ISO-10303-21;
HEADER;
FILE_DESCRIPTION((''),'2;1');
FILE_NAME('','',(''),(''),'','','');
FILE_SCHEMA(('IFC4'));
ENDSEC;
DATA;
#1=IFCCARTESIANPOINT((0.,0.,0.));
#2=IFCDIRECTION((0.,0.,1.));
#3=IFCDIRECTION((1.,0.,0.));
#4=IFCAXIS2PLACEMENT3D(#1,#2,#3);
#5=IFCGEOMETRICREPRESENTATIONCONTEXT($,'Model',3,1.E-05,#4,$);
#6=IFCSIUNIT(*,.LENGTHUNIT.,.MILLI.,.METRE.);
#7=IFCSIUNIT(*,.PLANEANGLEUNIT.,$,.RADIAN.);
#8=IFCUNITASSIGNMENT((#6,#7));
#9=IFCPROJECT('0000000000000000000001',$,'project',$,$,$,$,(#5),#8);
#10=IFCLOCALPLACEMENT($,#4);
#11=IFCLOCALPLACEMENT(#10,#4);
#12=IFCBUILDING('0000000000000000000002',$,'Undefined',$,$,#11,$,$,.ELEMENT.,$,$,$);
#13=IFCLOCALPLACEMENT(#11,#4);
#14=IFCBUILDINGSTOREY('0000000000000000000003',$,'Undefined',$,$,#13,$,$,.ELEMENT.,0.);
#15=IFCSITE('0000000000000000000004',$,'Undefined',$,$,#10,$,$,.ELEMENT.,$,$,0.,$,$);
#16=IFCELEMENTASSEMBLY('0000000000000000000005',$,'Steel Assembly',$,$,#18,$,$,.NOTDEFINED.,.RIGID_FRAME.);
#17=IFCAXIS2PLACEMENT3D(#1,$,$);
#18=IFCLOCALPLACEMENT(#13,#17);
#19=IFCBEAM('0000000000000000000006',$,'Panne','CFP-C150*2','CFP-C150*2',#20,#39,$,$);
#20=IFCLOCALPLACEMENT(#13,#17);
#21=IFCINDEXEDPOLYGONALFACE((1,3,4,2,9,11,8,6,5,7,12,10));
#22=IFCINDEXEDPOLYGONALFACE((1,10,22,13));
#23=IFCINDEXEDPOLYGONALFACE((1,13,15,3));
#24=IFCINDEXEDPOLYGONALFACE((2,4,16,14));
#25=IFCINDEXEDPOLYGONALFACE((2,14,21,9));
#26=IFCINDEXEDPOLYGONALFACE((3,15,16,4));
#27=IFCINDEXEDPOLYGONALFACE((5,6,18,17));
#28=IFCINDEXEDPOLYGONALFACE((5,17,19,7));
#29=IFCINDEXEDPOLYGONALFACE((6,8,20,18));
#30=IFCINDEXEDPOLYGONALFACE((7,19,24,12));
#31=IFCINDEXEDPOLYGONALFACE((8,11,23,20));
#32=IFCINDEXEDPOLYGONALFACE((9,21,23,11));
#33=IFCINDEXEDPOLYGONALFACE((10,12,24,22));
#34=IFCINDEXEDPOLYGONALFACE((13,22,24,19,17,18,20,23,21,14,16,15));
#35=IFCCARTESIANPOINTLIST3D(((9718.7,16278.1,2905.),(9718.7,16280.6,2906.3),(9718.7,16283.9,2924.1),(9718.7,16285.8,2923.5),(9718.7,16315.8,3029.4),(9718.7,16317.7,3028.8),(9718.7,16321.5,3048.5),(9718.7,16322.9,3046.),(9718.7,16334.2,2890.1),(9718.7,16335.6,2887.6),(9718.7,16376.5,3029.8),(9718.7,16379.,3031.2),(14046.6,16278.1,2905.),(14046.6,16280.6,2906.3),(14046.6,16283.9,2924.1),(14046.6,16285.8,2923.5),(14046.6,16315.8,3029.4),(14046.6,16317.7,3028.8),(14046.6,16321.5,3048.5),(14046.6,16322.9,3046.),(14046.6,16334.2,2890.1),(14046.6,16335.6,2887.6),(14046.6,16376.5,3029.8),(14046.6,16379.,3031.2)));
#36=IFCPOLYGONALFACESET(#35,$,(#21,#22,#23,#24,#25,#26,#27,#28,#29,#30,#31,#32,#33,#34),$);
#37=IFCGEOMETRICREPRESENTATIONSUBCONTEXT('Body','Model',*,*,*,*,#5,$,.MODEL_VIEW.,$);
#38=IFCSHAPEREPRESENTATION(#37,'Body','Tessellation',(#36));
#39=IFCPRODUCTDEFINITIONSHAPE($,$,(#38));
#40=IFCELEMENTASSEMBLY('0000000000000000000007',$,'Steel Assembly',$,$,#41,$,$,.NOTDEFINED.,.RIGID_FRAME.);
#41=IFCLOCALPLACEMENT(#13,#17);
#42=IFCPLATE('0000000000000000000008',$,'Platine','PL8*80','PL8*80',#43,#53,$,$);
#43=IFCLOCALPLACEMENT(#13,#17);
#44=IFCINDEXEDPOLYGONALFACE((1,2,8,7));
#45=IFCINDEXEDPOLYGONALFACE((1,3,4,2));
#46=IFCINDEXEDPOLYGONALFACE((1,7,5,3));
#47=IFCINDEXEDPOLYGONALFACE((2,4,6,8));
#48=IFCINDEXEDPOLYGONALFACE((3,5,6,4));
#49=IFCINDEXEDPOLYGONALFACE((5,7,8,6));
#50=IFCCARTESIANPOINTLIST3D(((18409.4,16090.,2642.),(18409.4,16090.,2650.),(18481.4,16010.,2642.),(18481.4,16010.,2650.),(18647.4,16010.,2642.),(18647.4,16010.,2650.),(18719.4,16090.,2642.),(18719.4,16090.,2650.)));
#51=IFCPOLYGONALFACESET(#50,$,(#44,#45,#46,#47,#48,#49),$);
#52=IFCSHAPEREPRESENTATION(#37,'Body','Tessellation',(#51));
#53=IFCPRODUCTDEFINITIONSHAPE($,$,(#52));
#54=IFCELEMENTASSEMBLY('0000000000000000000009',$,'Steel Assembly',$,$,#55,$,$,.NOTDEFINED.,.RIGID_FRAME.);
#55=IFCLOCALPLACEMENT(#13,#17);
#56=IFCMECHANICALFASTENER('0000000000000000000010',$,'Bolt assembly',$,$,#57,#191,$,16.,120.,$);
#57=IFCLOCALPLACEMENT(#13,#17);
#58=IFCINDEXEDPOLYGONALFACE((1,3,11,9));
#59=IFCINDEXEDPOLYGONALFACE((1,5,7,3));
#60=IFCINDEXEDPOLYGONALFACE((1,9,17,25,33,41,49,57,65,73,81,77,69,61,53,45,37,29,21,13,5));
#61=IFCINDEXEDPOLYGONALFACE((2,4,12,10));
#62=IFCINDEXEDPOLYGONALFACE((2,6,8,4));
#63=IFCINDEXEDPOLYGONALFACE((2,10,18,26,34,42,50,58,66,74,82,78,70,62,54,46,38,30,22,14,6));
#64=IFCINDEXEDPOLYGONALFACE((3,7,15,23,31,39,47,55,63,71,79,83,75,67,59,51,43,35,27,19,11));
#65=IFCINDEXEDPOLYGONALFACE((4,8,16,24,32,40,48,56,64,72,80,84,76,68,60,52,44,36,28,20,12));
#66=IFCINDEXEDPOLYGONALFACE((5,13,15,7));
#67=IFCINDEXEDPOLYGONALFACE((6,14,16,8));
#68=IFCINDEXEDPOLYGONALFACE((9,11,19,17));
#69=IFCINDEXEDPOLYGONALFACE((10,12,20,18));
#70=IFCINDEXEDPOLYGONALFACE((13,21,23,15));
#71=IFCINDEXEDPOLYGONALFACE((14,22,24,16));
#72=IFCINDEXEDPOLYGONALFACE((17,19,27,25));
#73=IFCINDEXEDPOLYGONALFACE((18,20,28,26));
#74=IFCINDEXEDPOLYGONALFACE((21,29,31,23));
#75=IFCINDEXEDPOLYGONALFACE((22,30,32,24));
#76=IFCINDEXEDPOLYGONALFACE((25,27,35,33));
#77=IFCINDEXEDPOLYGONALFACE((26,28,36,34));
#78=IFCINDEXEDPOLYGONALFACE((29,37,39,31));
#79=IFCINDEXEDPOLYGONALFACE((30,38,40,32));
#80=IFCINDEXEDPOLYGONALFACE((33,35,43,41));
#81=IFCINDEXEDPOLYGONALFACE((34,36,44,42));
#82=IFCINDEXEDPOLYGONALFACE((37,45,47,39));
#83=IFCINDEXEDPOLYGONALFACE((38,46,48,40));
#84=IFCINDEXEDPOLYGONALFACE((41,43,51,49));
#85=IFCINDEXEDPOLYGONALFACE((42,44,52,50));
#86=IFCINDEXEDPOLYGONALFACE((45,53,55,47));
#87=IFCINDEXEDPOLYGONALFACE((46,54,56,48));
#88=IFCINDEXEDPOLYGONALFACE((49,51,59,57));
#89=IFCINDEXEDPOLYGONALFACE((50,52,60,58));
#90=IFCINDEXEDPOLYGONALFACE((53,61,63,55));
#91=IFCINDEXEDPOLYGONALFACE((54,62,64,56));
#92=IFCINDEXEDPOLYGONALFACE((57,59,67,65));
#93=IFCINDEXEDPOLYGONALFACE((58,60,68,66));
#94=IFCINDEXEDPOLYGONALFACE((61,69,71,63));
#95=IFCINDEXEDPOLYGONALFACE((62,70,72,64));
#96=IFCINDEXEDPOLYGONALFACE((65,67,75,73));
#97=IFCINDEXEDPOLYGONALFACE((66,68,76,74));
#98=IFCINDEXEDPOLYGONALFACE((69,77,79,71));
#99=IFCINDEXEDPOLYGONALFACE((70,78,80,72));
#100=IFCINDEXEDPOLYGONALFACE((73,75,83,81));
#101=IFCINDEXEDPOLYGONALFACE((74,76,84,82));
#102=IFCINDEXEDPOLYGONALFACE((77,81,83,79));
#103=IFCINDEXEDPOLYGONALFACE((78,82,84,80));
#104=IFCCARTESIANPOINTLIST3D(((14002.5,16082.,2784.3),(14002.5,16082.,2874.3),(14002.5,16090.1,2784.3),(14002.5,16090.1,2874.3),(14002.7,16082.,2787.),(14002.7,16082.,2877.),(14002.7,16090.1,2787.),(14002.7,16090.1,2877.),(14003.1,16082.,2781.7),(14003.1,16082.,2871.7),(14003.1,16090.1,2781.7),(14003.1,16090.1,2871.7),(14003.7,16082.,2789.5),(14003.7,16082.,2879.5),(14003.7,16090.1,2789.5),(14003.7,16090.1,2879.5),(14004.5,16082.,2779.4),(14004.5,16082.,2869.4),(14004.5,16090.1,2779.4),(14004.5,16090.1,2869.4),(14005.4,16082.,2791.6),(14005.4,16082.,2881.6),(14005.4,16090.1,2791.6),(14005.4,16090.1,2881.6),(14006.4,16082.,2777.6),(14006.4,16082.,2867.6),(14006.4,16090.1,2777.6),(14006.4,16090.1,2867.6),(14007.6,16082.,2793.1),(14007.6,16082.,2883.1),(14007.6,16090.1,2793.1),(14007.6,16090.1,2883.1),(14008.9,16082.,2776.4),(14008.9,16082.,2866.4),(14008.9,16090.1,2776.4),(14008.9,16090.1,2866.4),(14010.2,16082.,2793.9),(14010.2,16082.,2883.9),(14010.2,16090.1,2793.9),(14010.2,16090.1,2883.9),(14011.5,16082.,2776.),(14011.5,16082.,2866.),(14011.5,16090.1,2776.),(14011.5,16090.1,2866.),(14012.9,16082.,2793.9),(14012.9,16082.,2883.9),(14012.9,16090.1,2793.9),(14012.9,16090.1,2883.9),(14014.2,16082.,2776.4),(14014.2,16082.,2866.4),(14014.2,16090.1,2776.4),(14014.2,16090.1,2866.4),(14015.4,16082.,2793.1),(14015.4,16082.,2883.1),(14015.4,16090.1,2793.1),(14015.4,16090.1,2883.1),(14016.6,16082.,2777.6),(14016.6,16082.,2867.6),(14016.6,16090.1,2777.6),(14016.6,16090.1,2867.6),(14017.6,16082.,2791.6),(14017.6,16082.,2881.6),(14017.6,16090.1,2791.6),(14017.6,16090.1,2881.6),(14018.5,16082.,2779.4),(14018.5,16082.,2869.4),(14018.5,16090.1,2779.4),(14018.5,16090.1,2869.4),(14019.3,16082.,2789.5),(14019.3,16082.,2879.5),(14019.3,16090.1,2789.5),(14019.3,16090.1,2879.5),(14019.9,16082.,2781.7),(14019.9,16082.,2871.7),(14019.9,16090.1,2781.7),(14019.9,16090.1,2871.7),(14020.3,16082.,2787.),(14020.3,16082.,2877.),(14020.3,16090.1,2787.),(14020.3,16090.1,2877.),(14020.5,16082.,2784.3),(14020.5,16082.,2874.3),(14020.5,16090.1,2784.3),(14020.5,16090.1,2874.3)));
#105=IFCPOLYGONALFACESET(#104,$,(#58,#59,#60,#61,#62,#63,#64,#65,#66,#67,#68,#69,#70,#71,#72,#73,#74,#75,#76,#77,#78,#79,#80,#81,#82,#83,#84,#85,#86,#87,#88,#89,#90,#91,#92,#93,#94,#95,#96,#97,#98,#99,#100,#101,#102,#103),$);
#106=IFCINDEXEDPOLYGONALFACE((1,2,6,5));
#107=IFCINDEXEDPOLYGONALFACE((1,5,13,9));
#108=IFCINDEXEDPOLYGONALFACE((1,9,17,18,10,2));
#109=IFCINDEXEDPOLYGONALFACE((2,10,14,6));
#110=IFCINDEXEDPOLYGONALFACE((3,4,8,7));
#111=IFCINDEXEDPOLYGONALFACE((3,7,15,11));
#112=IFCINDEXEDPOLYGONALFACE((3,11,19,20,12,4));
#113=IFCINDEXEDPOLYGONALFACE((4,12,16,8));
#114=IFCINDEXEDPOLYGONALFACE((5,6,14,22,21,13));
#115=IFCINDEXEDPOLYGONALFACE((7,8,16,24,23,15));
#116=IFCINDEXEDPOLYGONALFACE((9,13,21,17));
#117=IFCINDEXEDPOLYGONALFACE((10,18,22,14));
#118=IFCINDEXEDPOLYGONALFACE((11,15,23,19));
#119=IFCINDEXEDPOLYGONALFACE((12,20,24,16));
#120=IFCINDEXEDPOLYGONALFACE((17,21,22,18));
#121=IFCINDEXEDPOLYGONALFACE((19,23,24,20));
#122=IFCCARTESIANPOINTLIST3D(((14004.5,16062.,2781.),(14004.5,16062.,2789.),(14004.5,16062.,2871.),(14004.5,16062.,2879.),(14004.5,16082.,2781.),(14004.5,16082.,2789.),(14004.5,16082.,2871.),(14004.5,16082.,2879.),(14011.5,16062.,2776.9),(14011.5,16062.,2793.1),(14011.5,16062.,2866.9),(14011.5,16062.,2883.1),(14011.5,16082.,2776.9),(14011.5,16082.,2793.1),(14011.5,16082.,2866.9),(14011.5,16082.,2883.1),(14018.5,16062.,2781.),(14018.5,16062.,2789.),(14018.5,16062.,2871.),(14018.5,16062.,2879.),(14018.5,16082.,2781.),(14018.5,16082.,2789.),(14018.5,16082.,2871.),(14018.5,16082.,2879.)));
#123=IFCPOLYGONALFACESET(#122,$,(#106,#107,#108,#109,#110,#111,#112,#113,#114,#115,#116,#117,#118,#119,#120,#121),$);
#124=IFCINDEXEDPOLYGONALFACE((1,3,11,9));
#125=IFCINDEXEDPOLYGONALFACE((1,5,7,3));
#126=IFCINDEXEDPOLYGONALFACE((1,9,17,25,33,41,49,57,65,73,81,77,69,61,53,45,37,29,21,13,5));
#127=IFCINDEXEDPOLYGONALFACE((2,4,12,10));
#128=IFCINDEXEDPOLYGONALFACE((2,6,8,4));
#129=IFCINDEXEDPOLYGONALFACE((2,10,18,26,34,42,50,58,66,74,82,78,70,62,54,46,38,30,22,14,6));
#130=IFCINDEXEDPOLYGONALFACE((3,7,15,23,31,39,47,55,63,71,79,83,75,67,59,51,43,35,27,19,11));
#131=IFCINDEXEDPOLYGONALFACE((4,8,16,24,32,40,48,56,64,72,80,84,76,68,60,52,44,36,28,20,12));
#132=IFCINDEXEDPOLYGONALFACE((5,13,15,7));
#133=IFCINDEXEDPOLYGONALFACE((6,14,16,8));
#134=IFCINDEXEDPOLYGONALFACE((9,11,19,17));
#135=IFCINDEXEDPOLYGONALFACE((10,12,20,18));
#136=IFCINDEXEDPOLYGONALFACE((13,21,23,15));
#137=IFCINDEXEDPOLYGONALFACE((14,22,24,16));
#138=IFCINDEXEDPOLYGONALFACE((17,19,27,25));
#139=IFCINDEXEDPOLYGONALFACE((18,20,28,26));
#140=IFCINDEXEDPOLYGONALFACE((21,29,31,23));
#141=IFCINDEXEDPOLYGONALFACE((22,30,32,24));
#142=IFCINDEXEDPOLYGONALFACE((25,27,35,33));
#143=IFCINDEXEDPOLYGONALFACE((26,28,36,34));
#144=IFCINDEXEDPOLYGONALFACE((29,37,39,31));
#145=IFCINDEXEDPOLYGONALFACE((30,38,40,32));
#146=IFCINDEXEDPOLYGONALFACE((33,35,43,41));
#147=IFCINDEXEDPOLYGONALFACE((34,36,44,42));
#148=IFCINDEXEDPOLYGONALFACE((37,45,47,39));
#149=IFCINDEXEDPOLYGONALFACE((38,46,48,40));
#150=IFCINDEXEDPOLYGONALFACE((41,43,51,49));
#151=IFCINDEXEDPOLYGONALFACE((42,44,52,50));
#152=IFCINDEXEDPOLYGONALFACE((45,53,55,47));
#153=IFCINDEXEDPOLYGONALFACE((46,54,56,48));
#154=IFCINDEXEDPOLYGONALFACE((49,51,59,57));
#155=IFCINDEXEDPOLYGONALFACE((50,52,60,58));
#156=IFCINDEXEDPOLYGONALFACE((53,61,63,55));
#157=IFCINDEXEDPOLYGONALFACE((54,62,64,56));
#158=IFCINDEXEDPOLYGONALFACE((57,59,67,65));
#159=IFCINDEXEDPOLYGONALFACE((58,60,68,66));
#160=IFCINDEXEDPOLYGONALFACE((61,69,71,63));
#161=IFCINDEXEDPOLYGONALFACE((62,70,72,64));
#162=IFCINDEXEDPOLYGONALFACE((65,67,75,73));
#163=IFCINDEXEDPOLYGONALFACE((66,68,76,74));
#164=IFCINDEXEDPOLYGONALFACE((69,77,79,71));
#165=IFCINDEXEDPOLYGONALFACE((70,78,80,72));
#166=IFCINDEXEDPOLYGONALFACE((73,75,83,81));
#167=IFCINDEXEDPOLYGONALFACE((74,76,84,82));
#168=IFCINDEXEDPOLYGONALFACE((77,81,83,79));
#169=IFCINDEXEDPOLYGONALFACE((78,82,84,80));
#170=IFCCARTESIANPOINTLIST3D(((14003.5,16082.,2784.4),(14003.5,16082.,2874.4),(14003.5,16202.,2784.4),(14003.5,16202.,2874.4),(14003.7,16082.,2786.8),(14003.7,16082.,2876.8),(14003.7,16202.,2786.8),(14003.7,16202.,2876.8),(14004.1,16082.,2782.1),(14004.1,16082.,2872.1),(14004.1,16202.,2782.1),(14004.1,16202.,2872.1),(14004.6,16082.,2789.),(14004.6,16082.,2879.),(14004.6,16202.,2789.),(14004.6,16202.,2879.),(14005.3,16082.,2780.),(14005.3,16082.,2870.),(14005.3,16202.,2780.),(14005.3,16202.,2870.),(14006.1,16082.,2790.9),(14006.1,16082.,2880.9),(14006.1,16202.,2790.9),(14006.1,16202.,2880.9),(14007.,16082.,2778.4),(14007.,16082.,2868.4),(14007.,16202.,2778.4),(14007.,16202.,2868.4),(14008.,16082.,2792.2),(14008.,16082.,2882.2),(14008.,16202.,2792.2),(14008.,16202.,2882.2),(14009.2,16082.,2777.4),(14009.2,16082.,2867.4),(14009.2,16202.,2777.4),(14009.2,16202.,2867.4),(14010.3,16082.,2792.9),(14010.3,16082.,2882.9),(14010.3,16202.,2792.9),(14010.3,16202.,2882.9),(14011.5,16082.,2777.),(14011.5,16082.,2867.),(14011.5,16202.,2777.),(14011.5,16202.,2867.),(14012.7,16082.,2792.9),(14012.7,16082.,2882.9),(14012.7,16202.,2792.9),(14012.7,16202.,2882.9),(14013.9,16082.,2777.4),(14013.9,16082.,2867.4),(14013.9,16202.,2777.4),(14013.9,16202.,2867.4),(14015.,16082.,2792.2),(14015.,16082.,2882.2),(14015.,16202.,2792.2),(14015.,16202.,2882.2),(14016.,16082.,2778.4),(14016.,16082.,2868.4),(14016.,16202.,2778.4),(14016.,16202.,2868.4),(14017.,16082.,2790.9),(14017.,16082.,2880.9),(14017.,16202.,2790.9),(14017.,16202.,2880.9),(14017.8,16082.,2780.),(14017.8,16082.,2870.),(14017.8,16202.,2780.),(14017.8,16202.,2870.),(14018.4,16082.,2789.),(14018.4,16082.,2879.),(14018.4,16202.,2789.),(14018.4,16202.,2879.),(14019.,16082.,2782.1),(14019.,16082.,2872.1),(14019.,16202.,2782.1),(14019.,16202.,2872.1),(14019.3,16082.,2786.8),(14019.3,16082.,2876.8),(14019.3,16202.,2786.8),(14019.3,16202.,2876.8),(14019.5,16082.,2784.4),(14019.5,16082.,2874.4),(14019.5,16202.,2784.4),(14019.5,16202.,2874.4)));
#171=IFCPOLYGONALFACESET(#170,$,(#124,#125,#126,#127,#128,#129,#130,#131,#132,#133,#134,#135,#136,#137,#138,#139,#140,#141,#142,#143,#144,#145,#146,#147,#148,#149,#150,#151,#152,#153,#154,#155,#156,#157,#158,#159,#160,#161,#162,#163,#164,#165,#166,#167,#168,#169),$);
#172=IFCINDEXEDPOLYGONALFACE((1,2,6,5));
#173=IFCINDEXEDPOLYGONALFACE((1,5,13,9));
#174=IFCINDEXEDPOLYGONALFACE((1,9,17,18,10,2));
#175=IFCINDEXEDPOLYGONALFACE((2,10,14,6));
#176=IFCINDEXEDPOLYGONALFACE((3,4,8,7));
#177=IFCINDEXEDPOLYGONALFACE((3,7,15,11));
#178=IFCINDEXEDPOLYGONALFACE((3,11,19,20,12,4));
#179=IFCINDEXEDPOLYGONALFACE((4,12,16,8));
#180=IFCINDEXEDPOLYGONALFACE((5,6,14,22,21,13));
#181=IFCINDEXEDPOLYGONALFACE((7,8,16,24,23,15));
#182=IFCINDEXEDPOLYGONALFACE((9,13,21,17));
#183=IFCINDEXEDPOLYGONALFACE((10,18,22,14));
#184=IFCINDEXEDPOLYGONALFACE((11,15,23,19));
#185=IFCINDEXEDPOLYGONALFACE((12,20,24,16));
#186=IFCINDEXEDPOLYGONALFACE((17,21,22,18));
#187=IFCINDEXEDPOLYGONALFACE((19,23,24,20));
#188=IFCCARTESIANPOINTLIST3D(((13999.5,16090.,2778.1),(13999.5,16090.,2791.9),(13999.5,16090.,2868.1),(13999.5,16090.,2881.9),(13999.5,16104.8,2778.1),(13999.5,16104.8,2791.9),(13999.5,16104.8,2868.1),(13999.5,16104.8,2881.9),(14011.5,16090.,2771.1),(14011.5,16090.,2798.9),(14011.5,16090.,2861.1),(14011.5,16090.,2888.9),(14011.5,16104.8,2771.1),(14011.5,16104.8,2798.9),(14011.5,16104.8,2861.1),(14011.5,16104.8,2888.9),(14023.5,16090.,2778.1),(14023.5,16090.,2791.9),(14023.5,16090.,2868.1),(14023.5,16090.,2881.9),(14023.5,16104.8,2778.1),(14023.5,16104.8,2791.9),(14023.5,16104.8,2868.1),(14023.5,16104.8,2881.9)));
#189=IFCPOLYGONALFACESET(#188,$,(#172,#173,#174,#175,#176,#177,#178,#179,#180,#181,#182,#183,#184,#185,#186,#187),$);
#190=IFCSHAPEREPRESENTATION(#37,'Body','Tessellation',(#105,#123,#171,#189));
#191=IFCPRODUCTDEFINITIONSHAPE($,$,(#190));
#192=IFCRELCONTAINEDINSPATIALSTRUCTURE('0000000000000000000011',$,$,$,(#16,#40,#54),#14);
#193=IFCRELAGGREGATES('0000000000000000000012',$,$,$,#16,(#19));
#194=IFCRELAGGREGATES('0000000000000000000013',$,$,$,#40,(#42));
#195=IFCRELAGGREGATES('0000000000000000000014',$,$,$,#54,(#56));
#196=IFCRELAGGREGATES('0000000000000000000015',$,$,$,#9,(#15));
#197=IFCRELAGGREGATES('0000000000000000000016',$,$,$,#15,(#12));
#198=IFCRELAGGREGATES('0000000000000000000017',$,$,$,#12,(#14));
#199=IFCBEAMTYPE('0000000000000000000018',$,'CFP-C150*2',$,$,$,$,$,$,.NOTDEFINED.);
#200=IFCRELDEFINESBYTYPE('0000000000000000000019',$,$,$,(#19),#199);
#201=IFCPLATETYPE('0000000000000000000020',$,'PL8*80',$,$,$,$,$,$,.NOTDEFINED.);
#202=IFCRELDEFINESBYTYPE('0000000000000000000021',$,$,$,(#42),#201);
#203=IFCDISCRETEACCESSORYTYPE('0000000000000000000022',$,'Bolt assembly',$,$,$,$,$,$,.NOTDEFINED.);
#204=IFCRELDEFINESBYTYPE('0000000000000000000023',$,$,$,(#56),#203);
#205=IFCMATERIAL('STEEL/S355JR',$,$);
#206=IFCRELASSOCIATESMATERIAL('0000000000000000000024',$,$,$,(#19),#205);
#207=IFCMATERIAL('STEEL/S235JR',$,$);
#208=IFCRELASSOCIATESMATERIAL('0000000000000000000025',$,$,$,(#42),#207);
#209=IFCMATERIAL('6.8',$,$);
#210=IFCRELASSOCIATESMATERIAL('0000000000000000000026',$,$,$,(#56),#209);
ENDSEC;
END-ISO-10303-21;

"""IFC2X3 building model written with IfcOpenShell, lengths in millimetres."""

from ifc_helpers import new_model, si_unit, frame, origin_with_axes, origin_2d_with_axis, place, context, subcontext, project, spatial, polyline, circle, c_section, outline, extrude, source, transform, mapped, material, type_object, element, aggregate, save


model = new_model("IFC2X3")

# Units and contexts
model_context = context("Model", 3, precision=1e-05, world=origin_with_axes())
body_context = subcontext(model_context, "Body", "Model", "MODEL_VIEW")
ifc_project = project(units=[si_unit("LENGTHUNIT", "METRE", prefix="MILLI"), si_unit("PLANEANGLEUNIT", "RADIAN")], contexts=[model_context])

# Site, building, storey
site_placement = place(None, origin_with_axes())
site = spatial("IfcSite", under=ifc_project, at=site_placement, Name="Undefined", CompositionType="ELEMENT", RefElevation=0.0)
building_placement = place(site_placement, origin_with_axes())
building = spatial("IfcBuilding", under=site, at=building_placement, Name="Undefined", CompositionType="ELEMENT")
storey_placement = place(building_placement, origin_with_axes())
storey = spatial("IfcBuildingStorey", under=building, at=storey_placement, Name="Undefined", CompositionType="ELEMENT", Elevation=0.0)

# Element assembly, beam
assembly_1_placement = place(storey_placement, origin_with_axes())
assembly_1 = element("IfcElementAssembly", 1, at=assembly_1_placement, inside=storey, Name="Steel Assembly", AssemblyPlace="NOTDEFINED", PredefinedType="RIGID_FRAME")
ifc_material_1 = material(Name="STEEL/S355JR")
beam_type = type_object("IfcBeamType", Name="CFP-C150*2", PredefinedType="NOTDEFINED")
beam_placement = place(assembly_1_placement, frame((14101.5, 16328.6, 2968.1), z_axis=(0.0, -0.289497, -0.957179), x_axis=(-1.0, 0.0, 0.0)))
beam = element("IfcBeam", 2, at=beam_placement, type_object=beam_type, material=ifc_material_1, Name="Panne", Description="CFP-C150*2", ObjectType="CFP-C150*2", context=body_context, shape_type="SweptSolid", body=[
    extrude(c_section(Depth=150.0, Width=60.0, WallThickness=2.0, Girth=20.0, at=origin_2d_with_axis()), frame((4382.9, 0.0, 0.0), z_axis=(-1.0, 0.0, 0.0), x_axis=(0.0, -1.0, 0.0)), (0.0, 0.0, 1.0), 4327.9),
])

# Element assembly, plate
assembly_2_placement = place(storey_placement, origin_with_axes())
assembly_2 = element("IfcElementAssembly", 3, at=assembly_2_placement, inside=storey, Name="Steel Assembly", AssemblyPlace="NOTDEFINED", PredefinedType="RIGID_FRAME")
ifc_material_2 = material(Name="STEEL/S235JR")
plate_type = type_object("IfcPlateType", Name="PL8*80", PredefinedType="NOTDEFINED")
plate_placement = place(assembly_2_placement, frame((18409.4, 16090.0, 2646.0), z_axis=(0.0, 0.0, 1.0), x_axis=(0.668965, -0.743294, 0.0)))
plate = element("IfcPlate", 4, at=plate_placement, type_object=plate_type, material=ifc_material_2, Name="Platine", Description="PL8*80", ObjectType="PL8*80", context=body_context, shape_type="SweptSolid", body=[
    extrude(outline(polyline([(0.0, 0.0), (107.6, 0.0), (218.7, 123.4), (207.4, 230.4), (0.0, 0.0)])), frame((0.0, 0.0, -4.0), z_axis=(0.0, 0.0, 1.0), x_axis=(1.0, 0.0, 0.0)), (0.0, 0.0, 1.0), 8.0),
])

# Element assembly, mechanical fastener
assembly_3_placement = place(storey_placement, origin_with_axes())
assembly_3 = element("IfcElementAssembly", 5, at=assembly_3_placement, inside=storey, Name="Steel Assembly", AssemblyPlace="NOTDEFINED", PredefinedType="RIGID_FRAME")
ifc_material_3 = material(Name="6.8")
discrete_accessory_type_1 = type_object("IfcDiscreteAccessoryType", Name="Bolt assembly")
shared_shape_1 = source(origin_with_axes(), body_context, "Body", "SweptSolid", [
    extrude(circle(Radius=9.0, at=origin_2d_with_axis()), frame((0.0, -8.0, 0.0), z_axis=(0.0, 1.0, 0.0), x_axis=(1.0, 0.0, 0.0)), (0.0, 0.0, 1.0), 8.1),
    extrude(outline(polyline([(8.1, 0.0), (4.0, 7.0), (-4.0, 7.0), (-8.1, 0.0), (-4.0, -7.0), (4.0, -7.0), (8.1, 0.0)])), frame((0.0, -28.0, 0.0), z_axis=(0.0, 1.0, 0.0), x_axis=(1.0, 0.0, 0.0)), (0.0, 0.0, 1.0), 20.0),
    extrude(circle(Radius=8.0, at=origin_2d_with_axis()), frame((0.0, -8.0, 0.0), z_axis=(0.0, 1.0, 0.0), x_axis=(1.0, 0.0, 0.0)), (0.0, 0.0, 1.0), 120.0),
    extrude(outline(polyline([(13.9, 0.0), (6.9, 12.0), (-6.9, 12.0), (-13.9, 0.0), (-6.9, -12.0), (6.9, -12.0), (13.9, 0.0)])), frame((0.0, 0.0, 0.0), z_axis=(0.0, 1.0, 0.0), x_axis=(1.0, 0.0, 0.0)), (0.0, 0.0, 1.0), 14.8),
])
mechanical_fastener_1_placement = place(assembly_3_placement, frame((14011.5, 16090.0, 2875.0), z_axis=(1.0, 0.0, 0.0), x_axis=(0.0, 0.0, -1.0)))
mechanical_fastener_1 = element("IfcMechanicalFastener", 6, at=mechanical_fastener_1_placement, type_object=discrete_accessory_type_1, material=ifc_material_3, Name="Bolt assembly", NominalDiameter=16.0, NominalLength=120.0, context=body_context, shape_type="MappedRepresentation", body=[
    mapped(shared_shape_1, transform((0.0, 0.0, 0.0))),
    mapped(shared_shape_1, transform((90.0, 0.0, 0.0))),
])

aggregate(assembly_1, [beam])

aggregate(assembly_2, [plate])
aggregate(assembly_3, [mechanical_fastener_1])

save(model, "model.ifc")
